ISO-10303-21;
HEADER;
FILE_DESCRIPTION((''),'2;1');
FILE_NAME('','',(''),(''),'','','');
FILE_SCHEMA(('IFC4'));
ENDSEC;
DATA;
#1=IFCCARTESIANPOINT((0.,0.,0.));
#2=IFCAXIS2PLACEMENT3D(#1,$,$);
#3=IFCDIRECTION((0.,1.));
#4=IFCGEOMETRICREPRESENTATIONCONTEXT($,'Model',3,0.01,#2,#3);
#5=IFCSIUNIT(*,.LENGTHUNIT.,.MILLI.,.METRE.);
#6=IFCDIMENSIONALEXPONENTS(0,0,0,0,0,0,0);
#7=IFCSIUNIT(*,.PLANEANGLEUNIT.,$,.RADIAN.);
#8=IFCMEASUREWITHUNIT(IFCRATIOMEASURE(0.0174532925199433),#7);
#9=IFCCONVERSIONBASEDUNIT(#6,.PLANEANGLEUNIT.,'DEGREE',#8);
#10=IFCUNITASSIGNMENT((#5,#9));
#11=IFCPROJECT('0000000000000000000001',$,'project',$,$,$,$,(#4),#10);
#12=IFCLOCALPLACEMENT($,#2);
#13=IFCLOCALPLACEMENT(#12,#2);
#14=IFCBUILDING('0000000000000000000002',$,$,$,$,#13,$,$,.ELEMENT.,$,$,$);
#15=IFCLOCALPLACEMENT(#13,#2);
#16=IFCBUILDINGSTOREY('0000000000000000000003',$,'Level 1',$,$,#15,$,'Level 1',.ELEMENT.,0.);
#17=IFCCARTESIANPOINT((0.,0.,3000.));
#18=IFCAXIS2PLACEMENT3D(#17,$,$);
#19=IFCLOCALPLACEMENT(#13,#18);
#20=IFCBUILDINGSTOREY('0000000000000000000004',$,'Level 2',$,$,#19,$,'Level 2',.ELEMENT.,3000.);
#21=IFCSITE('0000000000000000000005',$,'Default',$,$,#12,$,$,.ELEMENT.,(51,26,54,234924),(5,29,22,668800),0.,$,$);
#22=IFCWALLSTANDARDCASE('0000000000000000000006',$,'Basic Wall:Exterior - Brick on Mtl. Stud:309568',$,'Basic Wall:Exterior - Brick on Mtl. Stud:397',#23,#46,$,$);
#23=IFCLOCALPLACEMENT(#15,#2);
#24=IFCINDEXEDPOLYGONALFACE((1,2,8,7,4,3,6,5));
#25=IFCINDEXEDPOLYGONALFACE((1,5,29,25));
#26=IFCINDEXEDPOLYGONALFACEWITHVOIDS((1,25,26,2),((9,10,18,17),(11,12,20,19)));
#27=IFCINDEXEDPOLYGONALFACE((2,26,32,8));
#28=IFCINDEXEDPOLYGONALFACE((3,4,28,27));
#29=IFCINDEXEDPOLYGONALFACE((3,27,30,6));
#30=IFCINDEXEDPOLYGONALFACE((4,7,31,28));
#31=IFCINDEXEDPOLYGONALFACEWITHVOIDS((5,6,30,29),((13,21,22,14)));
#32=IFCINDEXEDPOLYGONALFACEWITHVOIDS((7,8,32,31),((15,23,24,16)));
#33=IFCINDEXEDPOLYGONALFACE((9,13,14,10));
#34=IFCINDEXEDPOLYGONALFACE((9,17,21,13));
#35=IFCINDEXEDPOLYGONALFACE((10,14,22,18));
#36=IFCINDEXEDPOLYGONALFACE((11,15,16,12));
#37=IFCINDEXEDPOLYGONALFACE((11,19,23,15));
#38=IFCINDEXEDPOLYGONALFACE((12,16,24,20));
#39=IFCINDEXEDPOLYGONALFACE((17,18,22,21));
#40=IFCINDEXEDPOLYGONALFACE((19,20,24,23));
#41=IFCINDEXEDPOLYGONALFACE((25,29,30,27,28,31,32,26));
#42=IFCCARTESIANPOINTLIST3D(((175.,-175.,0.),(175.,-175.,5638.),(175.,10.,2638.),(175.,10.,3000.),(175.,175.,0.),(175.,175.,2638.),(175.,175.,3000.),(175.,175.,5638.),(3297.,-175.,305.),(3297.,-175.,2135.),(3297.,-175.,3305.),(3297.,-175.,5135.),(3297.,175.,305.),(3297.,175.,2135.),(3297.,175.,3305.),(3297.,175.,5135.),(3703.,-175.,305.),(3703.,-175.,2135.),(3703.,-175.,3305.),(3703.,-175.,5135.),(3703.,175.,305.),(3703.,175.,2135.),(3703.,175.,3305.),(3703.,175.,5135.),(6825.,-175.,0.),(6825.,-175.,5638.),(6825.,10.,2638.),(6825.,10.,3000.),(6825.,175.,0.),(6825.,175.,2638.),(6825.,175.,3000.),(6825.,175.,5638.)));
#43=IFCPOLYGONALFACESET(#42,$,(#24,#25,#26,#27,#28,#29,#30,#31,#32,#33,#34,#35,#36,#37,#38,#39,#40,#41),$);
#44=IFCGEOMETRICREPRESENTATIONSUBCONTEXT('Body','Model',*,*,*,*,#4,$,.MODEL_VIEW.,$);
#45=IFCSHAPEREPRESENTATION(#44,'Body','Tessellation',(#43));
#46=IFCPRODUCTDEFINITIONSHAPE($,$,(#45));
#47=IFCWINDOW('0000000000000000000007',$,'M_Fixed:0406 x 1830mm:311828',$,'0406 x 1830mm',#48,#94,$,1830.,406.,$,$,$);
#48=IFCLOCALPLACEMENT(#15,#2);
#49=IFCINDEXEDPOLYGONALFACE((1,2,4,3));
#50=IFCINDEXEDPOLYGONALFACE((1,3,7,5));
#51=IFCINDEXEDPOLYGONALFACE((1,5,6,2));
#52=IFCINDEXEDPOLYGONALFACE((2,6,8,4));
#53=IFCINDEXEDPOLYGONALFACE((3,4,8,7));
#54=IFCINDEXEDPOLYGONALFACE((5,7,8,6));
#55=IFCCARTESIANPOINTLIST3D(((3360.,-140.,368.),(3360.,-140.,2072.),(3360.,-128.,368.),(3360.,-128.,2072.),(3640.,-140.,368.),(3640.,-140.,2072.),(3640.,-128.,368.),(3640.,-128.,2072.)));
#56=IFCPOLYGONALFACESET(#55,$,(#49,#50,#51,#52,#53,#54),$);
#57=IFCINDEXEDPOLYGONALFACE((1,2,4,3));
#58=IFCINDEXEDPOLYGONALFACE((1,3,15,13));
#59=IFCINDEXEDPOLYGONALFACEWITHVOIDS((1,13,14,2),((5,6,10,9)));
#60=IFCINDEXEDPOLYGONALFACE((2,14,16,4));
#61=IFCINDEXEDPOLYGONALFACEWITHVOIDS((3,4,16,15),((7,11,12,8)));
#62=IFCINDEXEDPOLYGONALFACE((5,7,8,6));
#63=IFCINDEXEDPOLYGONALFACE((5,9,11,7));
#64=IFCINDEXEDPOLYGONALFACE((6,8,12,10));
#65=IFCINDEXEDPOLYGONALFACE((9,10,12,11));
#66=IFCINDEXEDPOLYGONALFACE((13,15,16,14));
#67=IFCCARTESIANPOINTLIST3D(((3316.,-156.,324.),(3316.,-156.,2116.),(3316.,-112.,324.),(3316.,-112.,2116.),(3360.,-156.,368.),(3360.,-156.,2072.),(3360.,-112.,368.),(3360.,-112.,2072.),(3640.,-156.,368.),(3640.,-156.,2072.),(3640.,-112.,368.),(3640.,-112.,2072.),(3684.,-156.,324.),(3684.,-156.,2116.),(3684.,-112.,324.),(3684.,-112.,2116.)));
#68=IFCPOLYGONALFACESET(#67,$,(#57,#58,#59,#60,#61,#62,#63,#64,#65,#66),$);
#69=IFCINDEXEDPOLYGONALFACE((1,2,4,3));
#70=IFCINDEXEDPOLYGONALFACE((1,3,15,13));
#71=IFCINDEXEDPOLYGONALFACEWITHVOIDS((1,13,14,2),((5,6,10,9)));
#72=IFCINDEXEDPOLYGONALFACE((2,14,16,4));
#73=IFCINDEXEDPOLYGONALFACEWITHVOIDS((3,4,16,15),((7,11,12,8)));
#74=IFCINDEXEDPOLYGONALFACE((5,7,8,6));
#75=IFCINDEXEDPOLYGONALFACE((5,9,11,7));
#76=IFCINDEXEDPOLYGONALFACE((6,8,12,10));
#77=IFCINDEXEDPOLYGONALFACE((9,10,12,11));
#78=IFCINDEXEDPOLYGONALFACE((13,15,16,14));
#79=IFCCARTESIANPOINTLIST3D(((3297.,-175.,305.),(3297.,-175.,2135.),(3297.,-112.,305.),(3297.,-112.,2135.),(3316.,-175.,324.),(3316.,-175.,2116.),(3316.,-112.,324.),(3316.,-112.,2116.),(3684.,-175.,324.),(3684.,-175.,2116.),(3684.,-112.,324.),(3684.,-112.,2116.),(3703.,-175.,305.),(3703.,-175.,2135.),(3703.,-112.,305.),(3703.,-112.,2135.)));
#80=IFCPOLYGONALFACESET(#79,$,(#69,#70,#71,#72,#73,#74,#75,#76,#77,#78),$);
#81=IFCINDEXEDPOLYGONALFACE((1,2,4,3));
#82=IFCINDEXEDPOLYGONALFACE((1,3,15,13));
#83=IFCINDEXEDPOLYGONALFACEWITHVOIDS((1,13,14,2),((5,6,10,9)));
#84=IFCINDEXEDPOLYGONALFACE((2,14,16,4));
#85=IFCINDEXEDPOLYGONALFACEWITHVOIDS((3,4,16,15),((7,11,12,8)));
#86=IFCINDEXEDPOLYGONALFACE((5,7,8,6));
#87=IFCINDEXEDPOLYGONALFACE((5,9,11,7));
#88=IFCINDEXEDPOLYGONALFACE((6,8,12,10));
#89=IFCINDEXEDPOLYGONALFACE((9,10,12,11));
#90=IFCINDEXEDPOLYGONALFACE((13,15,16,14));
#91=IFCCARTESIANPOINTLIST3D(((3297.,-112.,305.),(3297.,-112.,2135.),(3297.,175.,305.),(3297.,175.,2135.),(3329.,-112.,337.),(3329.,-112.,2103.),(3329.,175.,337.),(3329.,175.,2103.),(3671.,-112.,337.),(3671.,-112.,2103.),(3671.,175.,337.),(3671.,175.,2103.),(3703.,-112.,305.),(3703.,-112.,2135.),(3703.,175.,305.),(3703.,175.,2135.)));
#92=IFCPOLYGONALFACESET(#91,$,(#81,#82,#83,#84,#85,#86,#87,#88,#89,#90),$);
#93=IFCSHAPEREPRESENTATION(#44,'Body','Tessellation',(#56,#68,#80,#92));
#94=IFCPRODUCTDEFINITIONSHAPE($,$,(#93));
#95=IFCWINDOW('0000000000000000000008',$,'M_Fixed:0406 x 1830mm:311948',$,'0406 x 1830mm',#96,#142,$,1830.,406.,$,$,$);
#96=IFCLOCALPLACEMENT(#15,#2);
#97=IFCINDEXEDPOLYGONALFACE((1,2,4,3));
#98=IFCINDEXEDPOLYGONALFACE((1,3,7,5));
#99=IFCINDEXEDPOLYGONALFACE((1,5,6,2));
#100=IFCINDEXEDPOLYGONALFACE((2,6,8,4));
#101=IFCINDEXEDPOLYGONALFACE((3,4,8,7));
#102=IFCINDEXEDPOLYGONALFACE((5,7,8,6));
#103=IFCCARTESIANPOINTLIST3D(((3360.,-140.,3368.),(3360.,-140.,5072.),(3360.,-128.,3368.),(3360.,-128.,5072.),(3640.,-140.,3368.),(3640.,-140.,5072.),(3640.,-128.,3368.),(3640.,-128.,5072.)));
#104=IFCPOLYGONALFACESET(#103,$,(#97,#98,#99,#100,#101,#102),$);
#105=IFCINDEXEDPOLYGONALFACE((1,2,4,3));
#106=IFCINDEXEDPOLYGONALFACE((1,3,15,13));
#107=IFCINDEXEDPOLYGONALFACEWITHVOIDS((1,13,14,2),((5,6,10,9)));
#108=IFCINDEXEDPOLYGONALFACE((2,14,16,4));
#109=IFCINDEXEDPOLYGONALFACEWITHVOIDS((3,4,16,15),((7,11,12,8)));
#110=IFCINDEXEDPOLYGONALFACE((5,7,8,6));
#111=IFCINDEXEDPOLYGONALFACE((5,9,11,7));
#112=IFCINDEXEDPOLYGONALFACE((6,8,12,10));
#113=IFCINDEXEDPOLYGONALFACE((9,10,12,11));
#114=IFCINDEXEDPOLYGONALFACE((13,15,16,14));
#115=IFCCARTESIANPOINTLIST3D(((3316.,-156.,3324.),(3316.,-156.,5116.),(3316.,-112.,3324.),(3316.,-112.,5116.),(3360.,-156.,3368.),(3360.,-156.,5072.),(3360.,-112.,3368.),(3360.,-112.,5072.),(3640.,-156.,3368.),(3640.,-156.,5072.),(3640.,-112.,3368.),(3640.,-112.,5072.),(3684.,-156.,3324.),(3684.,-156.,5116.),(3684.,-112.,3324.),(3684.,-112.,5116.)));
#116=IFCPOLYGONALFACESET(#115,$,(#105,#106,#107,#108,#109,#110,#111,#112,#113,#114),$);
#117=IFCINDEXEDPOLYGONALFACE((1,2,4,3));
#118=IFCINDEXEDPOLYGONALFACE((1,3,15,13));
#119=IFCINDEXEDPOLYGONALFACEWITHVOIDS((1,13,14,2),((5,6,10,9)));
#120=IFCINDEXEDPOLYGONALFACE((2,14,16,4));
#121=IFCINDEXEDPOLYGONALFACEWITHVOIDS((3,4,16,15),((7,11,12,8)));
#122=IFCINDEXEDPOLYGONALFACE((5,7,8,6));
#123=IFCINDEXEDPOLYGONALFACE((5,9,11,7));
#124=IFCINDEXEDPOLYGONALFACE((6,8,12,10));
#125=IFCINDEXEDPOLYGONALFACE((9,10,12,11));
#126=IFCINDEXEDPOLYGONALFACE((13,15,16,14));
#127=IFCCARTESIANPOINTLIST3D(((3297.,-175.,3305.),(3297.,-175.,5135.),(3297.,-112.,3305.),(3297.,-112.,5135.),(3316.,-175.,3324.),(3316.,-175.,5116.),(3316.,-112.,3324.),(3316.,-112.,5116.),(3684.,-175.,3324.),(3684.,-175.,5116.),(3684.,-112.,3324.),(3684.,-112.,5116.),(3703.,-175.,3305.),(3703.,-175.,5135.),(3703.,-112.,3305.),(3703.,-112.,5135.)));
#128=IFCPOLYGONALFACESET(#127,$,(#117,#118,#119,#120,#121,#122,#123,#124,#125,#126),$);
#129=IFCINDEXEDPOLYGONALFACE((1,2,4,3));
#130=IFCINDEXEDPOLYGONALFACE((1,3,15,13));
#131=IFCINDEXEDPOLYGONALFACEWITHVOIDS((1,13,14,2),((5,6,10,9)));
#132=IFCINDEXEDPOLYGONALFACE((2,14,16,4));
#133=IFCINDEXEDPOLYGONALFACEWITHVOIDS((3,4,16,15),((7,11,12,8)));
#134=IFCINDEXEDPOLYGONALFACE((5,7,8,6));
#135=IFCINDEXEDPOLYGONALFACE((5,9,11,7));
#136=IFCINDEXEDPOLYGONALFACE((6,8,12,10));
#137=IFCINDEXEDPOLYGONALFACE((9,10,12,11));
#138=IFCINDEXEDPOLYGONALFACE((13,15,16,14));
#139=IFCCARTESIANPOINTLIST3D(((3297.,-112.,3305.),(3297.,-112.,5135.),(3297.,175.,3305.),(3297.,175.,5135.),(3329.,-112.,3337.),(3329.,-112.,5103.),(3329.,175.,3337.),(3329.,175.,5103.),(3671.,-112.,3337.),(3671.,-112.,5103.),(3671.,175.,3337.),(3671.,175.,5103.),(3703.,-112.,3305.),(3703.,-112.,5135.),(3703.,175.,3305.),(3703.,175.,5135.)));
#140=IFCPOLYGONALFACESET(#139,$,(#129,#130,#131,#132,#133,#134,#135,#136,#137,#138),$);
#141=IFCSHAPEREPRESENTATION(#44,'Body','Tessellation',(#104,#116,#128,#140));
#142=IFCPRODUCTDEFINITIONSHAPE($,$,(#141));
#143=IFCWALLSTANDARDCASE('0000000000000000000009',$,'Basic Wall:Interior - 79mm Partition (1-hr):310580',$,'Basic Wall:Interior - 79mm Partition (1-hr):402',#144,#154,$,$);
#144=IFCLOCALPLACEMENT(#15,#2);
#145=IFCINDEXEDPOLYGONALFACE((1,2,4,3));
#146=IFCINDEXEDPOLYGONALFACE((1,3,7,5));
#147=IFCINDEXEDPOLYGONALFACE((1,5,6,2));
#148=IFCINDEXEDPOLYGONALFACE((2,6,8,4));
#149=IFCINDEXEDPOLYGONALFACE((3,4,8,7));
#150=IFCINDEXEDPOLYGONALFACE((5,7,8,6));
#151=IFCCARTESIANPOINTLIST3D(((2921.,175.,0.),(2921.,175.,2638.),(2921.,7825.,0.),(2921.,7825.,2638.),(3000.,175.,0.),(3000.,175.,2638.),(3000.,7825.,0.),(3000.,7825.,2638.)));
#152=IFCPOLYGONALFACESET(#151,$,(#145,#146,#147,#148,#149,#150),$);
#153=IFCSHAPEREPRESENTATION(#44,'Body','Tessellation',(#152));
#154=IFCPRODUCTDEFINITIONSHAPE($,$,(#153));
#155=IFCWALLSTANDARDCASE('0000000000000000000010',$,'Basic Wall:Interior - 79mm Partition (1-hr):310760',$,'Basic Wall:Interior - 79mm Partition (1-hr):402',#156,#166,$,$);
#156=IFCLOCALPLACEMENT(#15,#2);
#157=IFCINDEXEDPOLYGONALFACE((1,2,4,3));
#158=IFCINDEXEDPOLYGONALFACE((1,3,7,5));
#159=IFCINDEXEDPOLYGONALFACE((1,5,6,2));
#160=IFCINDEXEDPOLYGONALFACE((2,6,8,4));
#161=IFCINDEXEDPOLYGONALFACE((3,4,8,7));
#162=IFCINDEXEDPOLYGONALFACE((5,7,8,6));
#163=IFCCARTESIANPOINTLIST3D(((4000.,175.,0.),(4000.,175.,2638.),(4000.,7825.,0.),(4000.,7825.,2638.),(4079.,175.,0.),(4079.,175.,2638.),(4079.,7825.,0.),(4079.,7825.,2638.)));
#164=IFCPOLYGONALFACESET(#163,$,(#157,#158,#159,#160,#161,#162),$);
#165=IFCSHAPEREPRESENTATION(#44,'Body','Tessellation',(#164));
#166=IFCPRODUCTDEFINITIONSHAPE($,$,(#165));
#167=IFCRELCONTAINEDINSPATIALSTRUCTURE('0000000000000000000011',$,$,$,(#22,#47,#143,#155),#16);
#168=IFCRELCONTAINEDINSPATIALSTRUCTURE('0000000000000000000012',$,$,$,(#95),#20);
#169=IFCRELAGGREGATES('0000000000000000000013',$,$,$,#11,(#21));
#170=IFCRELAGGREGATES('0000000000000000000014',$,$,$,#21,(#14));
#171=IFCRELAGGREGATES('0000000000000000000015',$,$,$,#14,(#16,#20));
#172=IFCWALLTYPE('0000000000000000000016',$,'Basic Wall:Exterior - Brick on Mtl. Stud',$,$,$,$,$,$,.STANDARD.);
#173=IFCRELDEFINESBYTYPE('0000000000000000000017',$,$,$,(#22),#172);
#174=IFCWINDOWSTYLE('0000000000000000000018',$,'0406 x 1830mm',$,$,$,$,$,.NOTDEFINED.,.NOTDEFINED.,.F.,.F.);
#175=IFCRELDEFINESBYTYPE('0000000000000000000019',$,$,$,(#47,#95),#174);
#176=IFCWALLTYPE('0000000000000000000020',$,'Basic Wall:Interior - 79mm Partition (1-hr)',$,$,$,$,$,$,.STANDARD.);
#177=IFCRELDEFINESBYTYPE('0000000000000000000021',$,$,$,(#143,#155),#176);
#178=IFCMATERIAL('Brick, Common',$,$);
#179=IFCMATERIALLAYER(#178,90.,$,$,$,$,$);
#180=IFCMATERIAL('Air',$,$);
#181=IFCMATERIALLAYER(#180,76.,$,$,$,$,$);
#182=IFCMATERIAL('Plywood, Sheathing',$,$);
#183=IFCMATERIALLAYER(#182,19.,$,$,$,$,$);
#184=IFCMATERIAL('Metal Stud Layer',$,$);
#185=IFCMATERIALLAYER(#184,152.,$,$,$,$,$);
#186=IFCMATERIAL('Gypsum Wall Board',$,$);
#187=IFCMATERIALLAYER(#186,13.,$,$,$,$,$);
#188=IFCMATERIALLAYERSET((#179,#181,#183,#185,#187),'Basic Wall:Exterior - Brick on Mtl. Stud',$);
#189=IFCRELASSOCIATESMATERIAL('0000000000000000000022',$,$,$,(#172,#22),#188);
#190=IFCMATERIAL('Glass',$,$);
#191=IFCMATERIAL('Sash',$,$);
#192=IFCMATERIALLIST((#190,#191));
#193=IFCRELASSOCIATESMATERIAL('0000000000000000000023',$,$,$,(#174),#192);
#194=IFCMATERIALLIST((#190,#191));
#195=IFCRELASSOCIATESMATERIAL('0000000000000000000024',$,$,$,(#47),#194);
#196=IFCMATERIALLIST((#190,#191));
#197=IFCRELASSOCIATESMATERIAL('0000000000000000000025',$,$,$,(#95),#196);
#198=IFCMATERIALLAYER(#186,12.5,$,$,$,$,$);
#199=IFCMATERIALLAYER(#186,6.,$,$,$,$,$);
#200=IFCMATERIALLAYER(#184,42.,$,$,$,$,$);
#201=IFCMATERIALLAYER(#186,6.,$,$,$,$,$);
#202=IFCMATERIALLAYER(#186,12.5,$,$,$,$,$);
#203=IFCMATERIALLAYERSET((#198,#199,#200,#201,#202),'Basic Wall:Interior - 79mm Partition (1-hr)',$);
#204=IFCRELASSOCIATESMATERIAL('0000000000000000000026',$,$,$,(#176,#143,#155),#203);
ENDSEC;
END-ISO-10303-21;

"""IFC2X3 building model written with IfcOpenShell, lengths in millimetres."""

from ifc_helpers import new_model, entity, si_unit, converted_unit, direction, frame, frame_2d, origin, place, context, subcontext, project, spatial, polyline, rectangle, outline, extrude, clip, bounded_halfspace, source, transform, mapped, material, material_list, layer, layer_set, layer_usage, type_object, type_shapes, element, fill, save


model = new_model("IFC2X3")

# Units and contexts
model_context = context("Model", 3, precision=0.01, world=origin(), true_north=direction((0.0, 1.0)))
body_context = subcontext(model_context, "Body", "Model", "MODEL_VIEW")
ifc_project = project(units=[si_unit("LENGTHUNIT", "METRE", prefix="MILLI"), converted_unit("PLANEANGLEUNIT", "DEGREE", entity("IfcRatioMeasure", 0.0174532925199433), si_unit("PLANEANGLEUNIT", "RADIAN"), dimensions=[0, 0, 0, 0, 0, 0, 0])], contexts=[model_context])

# Site, building, storey
site_placement = place(None, origin())
site = spatial("IfcSite", under=ifc_project, at=site_placement, Name="Default", CompositionType="ELEMENT", RefLatitude=(51, 26, 54, 234924), RefLongitude=(5, 29, 22, 668800), RefElevation=0.0)
building_placement = place(site_placement, origin())
building = spatial("IfcBuilding", under=site, at=building_placement, CompositionType="ELEMENT")
storey_1_placement = place(building_placement, origin())
storey_1 = spatial("IfcBuildingStorey", under=building, at=storey_1_placement, Name="Level 1", LongName="Level 1", CompositionType="ELEMENT", Elevation=0.0)

# Shared definitions
ifc_material_1 = material(Name="Brick, Common")
ifc_layer_1 = layer(ifc_material_1, 90.0)
ifc_material_2 = material(Name="Air")
ifc_layer_2 = layer(ifc_material_2, 76.0)
ifc_material_3 = material(Name="Plywood, Sheathing")
ifc_layer_3 = layer(ifc_material_3, 19.0)
ifc_material_4 = material(Name="Metal Stud Layer")
ifc_layer_4 = layer(ifc_material_4, 152.0)
ifc_material_5 = material(Name="Gypsum Wall Board")
ifc_layer_5 = layer(ifc_material_5, 13.0)
ifc_layer_set_1 = layer_set([ifc_layer_1, ifc_layer_2, ifc_layer_3, ifc_layer_4, ifc_layer_5], Name="Basic Wall:Exterior - Brick on Mtl. Stud")
wall_type_1 = type_object("IfcWallType", Name="Basic Wall:Exterior - Brick on Mtl. Stud", PredefinedType="STANDARD", material=ifc_layer_set_1)
ifc_material_6 = material(Name="Glass")
ifc_material_7 = material(Name="Sash")

# Shared definitions
storey_2_placement = place(building_placement, frame((0.0, 0.0, 3000.0)))
storey_2 = spatial("IfcBuildingStorey", under=building, at=storey_2_placement, Name="Level 2", LongName="Level 2", CompositionType="ELEMENT", Elevation=3000.0)

# Wall, openings, windows
ifc_material_list_1 = material_list([ifc_material_6, ifc_material_7])
window_style_1 = type_object("IfcWindowStyle", Name="0406 x 1830mm", ConstructionType="NOTDEFINED", OperationType="NOTDEFINED", ParameterTakesPrecedence=False, Sizeable=False, material=ifc_material_list_1)
shared_shape_1 = source(origin(), body_context, "Body", "SweptSolid", [
    extrude(rectangle(XDim=12.0, YDim=280.0, at=frame_2d((0.0, 0.0), x_axis=(1.0, 0.0))), frame((203.0, 309.0, 63.0), z_axis=(0.0, 0.0, 1.0), x_axis=(0.0, -1.0, 0.0)), (0.0, 0.0, 1.0), 1704.0),
    extrude(outline(polyline([(-184.0, -896.0), (184.0, -896.0), (184.0, 896.0), (-184.0, 896.0), (-184.0, -896.0)]), holes=[polyline([(-140.0, -852.0), (-140.0, 852.0), (140.0, 852.0), (140.0, -852.0), (-140.0, -852.0)])]), frame((203.0, 287.0, 915.0), z_axis=(0.0, 1.0, 0.0), x_axis=(1.0, 0.0, 0.0)), (0.0, 0.0, 1.0), 44.0),
    extrude(outline(polyline([(-203.0, -915.0), (203.0, -915.0), (203.0, 915.0), (-203.0, 915.0), (-203.0, -915.0)]), holes=[polyline([(-184.0, -896.0), (-184.0, 896.0), (184.0, 896.0), (184.0, -896.0), (-184.0, -896.0)])]), frame((203.0, 287.0, 915.0), z_axis=(0.0, 1.0, 0.0), x_axis=(1.0, 0.0, 0.0)), (0.0, 0.0, 1.0), 63.0),
    extrude(outline(polyline([(-203.0, -915.0), (203.0, -915.0), (203.0, 915.0), (-203.0, 915.0), (-203.0, -915.0)]), holes=[polyline([(-171.0, -883.0), (-171.0, 883.0), (171.0, 883.0), (171.0, -883.0), (-171.0, -883.0)])]), frame((203.0, 0.0, 915.0), z_axis=(0.0, 1.0, 0.0), x_axis=(1.0, 0.0, 0.0)), (0.0, 0.0, 1.0), 287.0),
])
type_shapes(window_style_1, [shared_shape_1])
ifc_layer_usage_1 = layer_usage(ifc_layer_set_1, "AXIS2", "NEGATIVE", 175.0)
wall_1_placement = place(storey_1_placement, frame((6825.0, 0.0, 0.0), z_axis=(0.0, 0.0, 1.0), x_axis=(-1.0, 0.0, 0.0)))
wall_1 = element("IfcWallStandardCase", 1, at=wall_1_placement, inside=storey_1, type_object=wall_type_1, material=ifc_layer_usage_1, Name="Basic Wall:Exterior - Brick on Mtl. Stud:309568", ObjectType="Basic Wall:Exterior - Brick on Mtl. Stud:397", context=body_context, shape_type="Clipping", body=[
    clip(clip(extrude(rectangle(XDim=6650.0, YDim=350.0, at=frame_2d((3325.0, 0.0), x_axis=(-1.0, 0.0))), origin(), (0.0, 0.0, 1.0), 5638.0), bounded_halfspace(frame((0.0, -175.0, 5638.0), z_axis=(0.0, 0.0, -1.0), x_axis=(0.0, 1.0, 0.0)), True, frame((0.0, -175.0, 5638.0)), polyline([(0.0, 0.0), (2746.0, 0.0), (2825.0, 0.0), (3825.0, 0.0), (3904.0, 0.0), (6650.0, 0.0), (6650.0, 165.0), (0.0, 165.0), (0.0, 0.0)]))), bounded_halfspace(frame((0.0, -10.0, 2638.0), z_axis=(0.0, 1.0, 0.0), x_axis=(0.0, 0.0, 1.0)), True, frame((0.0, -10.0, 2638.0), z_axis=(0.0, 1.0, 0.0), x_axis=(0.0, 0.0, 1.0)), polyline([(0.0, 0.0), (362.0, 0.0), (362.0, 6650.0), (0.0, 6650.0), (0.0, 0.0)]))),
])
opening_1_placement = place(wall_1_placement, frame((3122.0, -175.0, 305.0)))
opening_1 = element("IfcOpeningElement", 2, at=opening_1_placement, cuts=wall_1, ObjectType="Opening", context=body_context, shape_type="SweptSolid", body=[
    extrude(rectangle(XDim=1830.0, YDim=406.0, at=frame_2d((915.0, 203.0), x_axis=(1.0, 0.0))), frame((0.0, 0.0, 0.0), z_axis=(0.0, 1.0, 0.0), x_axis=(0.0, 0.0, 1.0)), (0.0, 0.0, 1.0), 350.0),
])
opening_2_placement = place(wall_1_placement, frame((3122.0, -175.0, 3305.0)))
opening_2 = element("IfcOpeningElement", 3, at=opening_2_placement, cuts=wall_1, ObjectType="Opening", context=body_context, shape_type="SweptSolid", body=[
    extrude(rectangle(XDim=1830.0, YDim=406.0, at=frame_2d((915.0, 203.0), x_axis=(1.0, 0.0))), frame((0.0, 0.0, 0.0), z_axis=(0.0, 1.0, 0.0), x_axis=(0.0, 0.0, 1.0)), (0.0, 0.0, 1.0), 350.0),
])
ifc_material_list_2 = material_list([ifc_material_6, ifc_material_7])
window_1_placement = place(opening_1_placement, origin())
window_1 = element("IfcWindow", 4, at=window_1_placement, inside=storey_1, type_object=window_style_1, material=ifc_material_list_2, Name="M_Fixed:0406 x 1830mm:311828", ObjectType="0406 x 1830mm", OverallHeight=1830.0, OverallWidth=406.0, context=body_context, shape_type="MappedRepresentation", body=[
    mapped(shared_shape_1, transform((0.0, 0.0, 0.0), scale=1.0)),
])
fill(opening_1, window_1)
ifc_material_list_3 = material_list([ifc_material_6, ifc_material_7])
window_2_placement = place(opening_2_placement, origin())
window_2 = element("IfcWindow", 5, at=window_2_placement, inside=storey_2, type_object=window_style_1, material=ifc_material_list_3, Name="M_Fixed:0406 x 1830mm:311948", ObjectType="0406 x 1830mm", OverallHeight=1830.0, OverallWidth=406.0, context=body_context, shape_type="MappedRepresentation", body=[
    mapped(shared_shape_1, transform((0.0, 0.0, 0.0), scale=1.0)),
])
fill(opening_2, window_2)

# Walls
ifc_layer_6 = layer(ifc_material_5, 12.5)
ifc_layer_7 = layer(ifc_material_5, 6.0)
ifc_layer_8 = layer(ifc_material_4, 42.0)
ifc_layer_9 = layer(ifc_material_5, 6.0)
ifc_layer_10 = layer(ifc_material_5, 12.5)
ifc_layer_set_2 = layer_set([ifc_layer_6, ifc_layer_7, ifc_layer_8, ifc_layer_9, ifc_layer_10], Name="Basic Wall:Interior - 79mm Partition (1-hr)")
ifc_layer_usage_2 = layer_usage(ifc_layer_set_2, "AXIS2", "NEGATIVE", 39.5)
wall_type_2 = type_object("IfcWallType", Name="Basic Wall:Interior - 79mm Partition (1-hr)", PredefinedType="STANDARD", material=ifc_layer_set_2)
wall_2_placement = place(storey_1_placement, frame((2960.5, 7825.0, 0.0), z_axis=(0.0, 0.0, 1.0), x_axis=(0.0, -1.0, 0.0)))
element("IfcWallStandardCase", 6, at=wall_2_placement, inside=storey_1, type_object=wall_type_2, material=ifc_layer_usage_2, Name="Basic Wall:Interior - 79mm Partition (1-hr):310580", ObjectType="Basic Wall:Interior - 79mm Partition (1-hr):402", context=body_context, shape_type="Clipping", body=[
    clip(extrude(rectangle(XDim=7650.0, YDim=79.0, at=frame_2d((3825.0, 0.0), x_axis=(-1.0, 0.0))), origin(), (0.0, 0.0, 1.0), 2638.0), bounded_halfspace(frame((0.0, -39.5, 2638.0), z_axis=(0.0, 0.0, -1.0), x_axis=(1.0, 0.0, 0.0)), True, frame((0.0, -39.5, 2638.0)), polyline([(0.0, 0.0), (3785.5, 0.0), (3864.5, 0.0), (7650.0, 0.0), (7650.0, 79.0), (0.0, 79.0), (0.0, 0.0)]))),
])
ifc_layer_usage_3 = layer_usage(ifc_layer_set_2, "AXIS2", "NEGATIVE", 39.5)
wall_3_placement = place(storey_1_placement, frame((4039.5, 7825.0, 0.0), z_axis=(0.0, 0.0, 1.0), x_axis=(0.0, -1.0, 0.0)))
element("IfcWallStandardCase", 7, at=wall_3_placement, inside=storey_1, type_object=wall_type_2, material=ifc_layer_usage_3, Name="Basic Wall:Interior - 79mm Partition (1-hr):310760", ObjectType="Basic Wall:Interior - 79mm Partition (1-hr):402", context=body_context, shape_type="Clipping", body=[
    clip(extrude(rectangle(XDim=7650.0, YDim=79.0, at=frame_2d((3825.0, 0.0), x_axis=(-1.0, 0.0))), origin(), (0.0, 0.0, 1.0), 2638.0), bounded_halfspace(frame((0.0, -39.5, 2638.0), z_axis=(0.0, 0.0, -1.0), x_axis=(1.0, 0.0, 0.0)), True, frame((0.0, -39.5, 2638.0)), polyline([(0.0, 0.0), (7650.0, 0.0), (7650.0, 79.0), (3864.5, 79.0), (3785.5, 79.0), (0.0, 79.0), (0.0, 0.0)]))),
])

save(model, "model.ifc")
